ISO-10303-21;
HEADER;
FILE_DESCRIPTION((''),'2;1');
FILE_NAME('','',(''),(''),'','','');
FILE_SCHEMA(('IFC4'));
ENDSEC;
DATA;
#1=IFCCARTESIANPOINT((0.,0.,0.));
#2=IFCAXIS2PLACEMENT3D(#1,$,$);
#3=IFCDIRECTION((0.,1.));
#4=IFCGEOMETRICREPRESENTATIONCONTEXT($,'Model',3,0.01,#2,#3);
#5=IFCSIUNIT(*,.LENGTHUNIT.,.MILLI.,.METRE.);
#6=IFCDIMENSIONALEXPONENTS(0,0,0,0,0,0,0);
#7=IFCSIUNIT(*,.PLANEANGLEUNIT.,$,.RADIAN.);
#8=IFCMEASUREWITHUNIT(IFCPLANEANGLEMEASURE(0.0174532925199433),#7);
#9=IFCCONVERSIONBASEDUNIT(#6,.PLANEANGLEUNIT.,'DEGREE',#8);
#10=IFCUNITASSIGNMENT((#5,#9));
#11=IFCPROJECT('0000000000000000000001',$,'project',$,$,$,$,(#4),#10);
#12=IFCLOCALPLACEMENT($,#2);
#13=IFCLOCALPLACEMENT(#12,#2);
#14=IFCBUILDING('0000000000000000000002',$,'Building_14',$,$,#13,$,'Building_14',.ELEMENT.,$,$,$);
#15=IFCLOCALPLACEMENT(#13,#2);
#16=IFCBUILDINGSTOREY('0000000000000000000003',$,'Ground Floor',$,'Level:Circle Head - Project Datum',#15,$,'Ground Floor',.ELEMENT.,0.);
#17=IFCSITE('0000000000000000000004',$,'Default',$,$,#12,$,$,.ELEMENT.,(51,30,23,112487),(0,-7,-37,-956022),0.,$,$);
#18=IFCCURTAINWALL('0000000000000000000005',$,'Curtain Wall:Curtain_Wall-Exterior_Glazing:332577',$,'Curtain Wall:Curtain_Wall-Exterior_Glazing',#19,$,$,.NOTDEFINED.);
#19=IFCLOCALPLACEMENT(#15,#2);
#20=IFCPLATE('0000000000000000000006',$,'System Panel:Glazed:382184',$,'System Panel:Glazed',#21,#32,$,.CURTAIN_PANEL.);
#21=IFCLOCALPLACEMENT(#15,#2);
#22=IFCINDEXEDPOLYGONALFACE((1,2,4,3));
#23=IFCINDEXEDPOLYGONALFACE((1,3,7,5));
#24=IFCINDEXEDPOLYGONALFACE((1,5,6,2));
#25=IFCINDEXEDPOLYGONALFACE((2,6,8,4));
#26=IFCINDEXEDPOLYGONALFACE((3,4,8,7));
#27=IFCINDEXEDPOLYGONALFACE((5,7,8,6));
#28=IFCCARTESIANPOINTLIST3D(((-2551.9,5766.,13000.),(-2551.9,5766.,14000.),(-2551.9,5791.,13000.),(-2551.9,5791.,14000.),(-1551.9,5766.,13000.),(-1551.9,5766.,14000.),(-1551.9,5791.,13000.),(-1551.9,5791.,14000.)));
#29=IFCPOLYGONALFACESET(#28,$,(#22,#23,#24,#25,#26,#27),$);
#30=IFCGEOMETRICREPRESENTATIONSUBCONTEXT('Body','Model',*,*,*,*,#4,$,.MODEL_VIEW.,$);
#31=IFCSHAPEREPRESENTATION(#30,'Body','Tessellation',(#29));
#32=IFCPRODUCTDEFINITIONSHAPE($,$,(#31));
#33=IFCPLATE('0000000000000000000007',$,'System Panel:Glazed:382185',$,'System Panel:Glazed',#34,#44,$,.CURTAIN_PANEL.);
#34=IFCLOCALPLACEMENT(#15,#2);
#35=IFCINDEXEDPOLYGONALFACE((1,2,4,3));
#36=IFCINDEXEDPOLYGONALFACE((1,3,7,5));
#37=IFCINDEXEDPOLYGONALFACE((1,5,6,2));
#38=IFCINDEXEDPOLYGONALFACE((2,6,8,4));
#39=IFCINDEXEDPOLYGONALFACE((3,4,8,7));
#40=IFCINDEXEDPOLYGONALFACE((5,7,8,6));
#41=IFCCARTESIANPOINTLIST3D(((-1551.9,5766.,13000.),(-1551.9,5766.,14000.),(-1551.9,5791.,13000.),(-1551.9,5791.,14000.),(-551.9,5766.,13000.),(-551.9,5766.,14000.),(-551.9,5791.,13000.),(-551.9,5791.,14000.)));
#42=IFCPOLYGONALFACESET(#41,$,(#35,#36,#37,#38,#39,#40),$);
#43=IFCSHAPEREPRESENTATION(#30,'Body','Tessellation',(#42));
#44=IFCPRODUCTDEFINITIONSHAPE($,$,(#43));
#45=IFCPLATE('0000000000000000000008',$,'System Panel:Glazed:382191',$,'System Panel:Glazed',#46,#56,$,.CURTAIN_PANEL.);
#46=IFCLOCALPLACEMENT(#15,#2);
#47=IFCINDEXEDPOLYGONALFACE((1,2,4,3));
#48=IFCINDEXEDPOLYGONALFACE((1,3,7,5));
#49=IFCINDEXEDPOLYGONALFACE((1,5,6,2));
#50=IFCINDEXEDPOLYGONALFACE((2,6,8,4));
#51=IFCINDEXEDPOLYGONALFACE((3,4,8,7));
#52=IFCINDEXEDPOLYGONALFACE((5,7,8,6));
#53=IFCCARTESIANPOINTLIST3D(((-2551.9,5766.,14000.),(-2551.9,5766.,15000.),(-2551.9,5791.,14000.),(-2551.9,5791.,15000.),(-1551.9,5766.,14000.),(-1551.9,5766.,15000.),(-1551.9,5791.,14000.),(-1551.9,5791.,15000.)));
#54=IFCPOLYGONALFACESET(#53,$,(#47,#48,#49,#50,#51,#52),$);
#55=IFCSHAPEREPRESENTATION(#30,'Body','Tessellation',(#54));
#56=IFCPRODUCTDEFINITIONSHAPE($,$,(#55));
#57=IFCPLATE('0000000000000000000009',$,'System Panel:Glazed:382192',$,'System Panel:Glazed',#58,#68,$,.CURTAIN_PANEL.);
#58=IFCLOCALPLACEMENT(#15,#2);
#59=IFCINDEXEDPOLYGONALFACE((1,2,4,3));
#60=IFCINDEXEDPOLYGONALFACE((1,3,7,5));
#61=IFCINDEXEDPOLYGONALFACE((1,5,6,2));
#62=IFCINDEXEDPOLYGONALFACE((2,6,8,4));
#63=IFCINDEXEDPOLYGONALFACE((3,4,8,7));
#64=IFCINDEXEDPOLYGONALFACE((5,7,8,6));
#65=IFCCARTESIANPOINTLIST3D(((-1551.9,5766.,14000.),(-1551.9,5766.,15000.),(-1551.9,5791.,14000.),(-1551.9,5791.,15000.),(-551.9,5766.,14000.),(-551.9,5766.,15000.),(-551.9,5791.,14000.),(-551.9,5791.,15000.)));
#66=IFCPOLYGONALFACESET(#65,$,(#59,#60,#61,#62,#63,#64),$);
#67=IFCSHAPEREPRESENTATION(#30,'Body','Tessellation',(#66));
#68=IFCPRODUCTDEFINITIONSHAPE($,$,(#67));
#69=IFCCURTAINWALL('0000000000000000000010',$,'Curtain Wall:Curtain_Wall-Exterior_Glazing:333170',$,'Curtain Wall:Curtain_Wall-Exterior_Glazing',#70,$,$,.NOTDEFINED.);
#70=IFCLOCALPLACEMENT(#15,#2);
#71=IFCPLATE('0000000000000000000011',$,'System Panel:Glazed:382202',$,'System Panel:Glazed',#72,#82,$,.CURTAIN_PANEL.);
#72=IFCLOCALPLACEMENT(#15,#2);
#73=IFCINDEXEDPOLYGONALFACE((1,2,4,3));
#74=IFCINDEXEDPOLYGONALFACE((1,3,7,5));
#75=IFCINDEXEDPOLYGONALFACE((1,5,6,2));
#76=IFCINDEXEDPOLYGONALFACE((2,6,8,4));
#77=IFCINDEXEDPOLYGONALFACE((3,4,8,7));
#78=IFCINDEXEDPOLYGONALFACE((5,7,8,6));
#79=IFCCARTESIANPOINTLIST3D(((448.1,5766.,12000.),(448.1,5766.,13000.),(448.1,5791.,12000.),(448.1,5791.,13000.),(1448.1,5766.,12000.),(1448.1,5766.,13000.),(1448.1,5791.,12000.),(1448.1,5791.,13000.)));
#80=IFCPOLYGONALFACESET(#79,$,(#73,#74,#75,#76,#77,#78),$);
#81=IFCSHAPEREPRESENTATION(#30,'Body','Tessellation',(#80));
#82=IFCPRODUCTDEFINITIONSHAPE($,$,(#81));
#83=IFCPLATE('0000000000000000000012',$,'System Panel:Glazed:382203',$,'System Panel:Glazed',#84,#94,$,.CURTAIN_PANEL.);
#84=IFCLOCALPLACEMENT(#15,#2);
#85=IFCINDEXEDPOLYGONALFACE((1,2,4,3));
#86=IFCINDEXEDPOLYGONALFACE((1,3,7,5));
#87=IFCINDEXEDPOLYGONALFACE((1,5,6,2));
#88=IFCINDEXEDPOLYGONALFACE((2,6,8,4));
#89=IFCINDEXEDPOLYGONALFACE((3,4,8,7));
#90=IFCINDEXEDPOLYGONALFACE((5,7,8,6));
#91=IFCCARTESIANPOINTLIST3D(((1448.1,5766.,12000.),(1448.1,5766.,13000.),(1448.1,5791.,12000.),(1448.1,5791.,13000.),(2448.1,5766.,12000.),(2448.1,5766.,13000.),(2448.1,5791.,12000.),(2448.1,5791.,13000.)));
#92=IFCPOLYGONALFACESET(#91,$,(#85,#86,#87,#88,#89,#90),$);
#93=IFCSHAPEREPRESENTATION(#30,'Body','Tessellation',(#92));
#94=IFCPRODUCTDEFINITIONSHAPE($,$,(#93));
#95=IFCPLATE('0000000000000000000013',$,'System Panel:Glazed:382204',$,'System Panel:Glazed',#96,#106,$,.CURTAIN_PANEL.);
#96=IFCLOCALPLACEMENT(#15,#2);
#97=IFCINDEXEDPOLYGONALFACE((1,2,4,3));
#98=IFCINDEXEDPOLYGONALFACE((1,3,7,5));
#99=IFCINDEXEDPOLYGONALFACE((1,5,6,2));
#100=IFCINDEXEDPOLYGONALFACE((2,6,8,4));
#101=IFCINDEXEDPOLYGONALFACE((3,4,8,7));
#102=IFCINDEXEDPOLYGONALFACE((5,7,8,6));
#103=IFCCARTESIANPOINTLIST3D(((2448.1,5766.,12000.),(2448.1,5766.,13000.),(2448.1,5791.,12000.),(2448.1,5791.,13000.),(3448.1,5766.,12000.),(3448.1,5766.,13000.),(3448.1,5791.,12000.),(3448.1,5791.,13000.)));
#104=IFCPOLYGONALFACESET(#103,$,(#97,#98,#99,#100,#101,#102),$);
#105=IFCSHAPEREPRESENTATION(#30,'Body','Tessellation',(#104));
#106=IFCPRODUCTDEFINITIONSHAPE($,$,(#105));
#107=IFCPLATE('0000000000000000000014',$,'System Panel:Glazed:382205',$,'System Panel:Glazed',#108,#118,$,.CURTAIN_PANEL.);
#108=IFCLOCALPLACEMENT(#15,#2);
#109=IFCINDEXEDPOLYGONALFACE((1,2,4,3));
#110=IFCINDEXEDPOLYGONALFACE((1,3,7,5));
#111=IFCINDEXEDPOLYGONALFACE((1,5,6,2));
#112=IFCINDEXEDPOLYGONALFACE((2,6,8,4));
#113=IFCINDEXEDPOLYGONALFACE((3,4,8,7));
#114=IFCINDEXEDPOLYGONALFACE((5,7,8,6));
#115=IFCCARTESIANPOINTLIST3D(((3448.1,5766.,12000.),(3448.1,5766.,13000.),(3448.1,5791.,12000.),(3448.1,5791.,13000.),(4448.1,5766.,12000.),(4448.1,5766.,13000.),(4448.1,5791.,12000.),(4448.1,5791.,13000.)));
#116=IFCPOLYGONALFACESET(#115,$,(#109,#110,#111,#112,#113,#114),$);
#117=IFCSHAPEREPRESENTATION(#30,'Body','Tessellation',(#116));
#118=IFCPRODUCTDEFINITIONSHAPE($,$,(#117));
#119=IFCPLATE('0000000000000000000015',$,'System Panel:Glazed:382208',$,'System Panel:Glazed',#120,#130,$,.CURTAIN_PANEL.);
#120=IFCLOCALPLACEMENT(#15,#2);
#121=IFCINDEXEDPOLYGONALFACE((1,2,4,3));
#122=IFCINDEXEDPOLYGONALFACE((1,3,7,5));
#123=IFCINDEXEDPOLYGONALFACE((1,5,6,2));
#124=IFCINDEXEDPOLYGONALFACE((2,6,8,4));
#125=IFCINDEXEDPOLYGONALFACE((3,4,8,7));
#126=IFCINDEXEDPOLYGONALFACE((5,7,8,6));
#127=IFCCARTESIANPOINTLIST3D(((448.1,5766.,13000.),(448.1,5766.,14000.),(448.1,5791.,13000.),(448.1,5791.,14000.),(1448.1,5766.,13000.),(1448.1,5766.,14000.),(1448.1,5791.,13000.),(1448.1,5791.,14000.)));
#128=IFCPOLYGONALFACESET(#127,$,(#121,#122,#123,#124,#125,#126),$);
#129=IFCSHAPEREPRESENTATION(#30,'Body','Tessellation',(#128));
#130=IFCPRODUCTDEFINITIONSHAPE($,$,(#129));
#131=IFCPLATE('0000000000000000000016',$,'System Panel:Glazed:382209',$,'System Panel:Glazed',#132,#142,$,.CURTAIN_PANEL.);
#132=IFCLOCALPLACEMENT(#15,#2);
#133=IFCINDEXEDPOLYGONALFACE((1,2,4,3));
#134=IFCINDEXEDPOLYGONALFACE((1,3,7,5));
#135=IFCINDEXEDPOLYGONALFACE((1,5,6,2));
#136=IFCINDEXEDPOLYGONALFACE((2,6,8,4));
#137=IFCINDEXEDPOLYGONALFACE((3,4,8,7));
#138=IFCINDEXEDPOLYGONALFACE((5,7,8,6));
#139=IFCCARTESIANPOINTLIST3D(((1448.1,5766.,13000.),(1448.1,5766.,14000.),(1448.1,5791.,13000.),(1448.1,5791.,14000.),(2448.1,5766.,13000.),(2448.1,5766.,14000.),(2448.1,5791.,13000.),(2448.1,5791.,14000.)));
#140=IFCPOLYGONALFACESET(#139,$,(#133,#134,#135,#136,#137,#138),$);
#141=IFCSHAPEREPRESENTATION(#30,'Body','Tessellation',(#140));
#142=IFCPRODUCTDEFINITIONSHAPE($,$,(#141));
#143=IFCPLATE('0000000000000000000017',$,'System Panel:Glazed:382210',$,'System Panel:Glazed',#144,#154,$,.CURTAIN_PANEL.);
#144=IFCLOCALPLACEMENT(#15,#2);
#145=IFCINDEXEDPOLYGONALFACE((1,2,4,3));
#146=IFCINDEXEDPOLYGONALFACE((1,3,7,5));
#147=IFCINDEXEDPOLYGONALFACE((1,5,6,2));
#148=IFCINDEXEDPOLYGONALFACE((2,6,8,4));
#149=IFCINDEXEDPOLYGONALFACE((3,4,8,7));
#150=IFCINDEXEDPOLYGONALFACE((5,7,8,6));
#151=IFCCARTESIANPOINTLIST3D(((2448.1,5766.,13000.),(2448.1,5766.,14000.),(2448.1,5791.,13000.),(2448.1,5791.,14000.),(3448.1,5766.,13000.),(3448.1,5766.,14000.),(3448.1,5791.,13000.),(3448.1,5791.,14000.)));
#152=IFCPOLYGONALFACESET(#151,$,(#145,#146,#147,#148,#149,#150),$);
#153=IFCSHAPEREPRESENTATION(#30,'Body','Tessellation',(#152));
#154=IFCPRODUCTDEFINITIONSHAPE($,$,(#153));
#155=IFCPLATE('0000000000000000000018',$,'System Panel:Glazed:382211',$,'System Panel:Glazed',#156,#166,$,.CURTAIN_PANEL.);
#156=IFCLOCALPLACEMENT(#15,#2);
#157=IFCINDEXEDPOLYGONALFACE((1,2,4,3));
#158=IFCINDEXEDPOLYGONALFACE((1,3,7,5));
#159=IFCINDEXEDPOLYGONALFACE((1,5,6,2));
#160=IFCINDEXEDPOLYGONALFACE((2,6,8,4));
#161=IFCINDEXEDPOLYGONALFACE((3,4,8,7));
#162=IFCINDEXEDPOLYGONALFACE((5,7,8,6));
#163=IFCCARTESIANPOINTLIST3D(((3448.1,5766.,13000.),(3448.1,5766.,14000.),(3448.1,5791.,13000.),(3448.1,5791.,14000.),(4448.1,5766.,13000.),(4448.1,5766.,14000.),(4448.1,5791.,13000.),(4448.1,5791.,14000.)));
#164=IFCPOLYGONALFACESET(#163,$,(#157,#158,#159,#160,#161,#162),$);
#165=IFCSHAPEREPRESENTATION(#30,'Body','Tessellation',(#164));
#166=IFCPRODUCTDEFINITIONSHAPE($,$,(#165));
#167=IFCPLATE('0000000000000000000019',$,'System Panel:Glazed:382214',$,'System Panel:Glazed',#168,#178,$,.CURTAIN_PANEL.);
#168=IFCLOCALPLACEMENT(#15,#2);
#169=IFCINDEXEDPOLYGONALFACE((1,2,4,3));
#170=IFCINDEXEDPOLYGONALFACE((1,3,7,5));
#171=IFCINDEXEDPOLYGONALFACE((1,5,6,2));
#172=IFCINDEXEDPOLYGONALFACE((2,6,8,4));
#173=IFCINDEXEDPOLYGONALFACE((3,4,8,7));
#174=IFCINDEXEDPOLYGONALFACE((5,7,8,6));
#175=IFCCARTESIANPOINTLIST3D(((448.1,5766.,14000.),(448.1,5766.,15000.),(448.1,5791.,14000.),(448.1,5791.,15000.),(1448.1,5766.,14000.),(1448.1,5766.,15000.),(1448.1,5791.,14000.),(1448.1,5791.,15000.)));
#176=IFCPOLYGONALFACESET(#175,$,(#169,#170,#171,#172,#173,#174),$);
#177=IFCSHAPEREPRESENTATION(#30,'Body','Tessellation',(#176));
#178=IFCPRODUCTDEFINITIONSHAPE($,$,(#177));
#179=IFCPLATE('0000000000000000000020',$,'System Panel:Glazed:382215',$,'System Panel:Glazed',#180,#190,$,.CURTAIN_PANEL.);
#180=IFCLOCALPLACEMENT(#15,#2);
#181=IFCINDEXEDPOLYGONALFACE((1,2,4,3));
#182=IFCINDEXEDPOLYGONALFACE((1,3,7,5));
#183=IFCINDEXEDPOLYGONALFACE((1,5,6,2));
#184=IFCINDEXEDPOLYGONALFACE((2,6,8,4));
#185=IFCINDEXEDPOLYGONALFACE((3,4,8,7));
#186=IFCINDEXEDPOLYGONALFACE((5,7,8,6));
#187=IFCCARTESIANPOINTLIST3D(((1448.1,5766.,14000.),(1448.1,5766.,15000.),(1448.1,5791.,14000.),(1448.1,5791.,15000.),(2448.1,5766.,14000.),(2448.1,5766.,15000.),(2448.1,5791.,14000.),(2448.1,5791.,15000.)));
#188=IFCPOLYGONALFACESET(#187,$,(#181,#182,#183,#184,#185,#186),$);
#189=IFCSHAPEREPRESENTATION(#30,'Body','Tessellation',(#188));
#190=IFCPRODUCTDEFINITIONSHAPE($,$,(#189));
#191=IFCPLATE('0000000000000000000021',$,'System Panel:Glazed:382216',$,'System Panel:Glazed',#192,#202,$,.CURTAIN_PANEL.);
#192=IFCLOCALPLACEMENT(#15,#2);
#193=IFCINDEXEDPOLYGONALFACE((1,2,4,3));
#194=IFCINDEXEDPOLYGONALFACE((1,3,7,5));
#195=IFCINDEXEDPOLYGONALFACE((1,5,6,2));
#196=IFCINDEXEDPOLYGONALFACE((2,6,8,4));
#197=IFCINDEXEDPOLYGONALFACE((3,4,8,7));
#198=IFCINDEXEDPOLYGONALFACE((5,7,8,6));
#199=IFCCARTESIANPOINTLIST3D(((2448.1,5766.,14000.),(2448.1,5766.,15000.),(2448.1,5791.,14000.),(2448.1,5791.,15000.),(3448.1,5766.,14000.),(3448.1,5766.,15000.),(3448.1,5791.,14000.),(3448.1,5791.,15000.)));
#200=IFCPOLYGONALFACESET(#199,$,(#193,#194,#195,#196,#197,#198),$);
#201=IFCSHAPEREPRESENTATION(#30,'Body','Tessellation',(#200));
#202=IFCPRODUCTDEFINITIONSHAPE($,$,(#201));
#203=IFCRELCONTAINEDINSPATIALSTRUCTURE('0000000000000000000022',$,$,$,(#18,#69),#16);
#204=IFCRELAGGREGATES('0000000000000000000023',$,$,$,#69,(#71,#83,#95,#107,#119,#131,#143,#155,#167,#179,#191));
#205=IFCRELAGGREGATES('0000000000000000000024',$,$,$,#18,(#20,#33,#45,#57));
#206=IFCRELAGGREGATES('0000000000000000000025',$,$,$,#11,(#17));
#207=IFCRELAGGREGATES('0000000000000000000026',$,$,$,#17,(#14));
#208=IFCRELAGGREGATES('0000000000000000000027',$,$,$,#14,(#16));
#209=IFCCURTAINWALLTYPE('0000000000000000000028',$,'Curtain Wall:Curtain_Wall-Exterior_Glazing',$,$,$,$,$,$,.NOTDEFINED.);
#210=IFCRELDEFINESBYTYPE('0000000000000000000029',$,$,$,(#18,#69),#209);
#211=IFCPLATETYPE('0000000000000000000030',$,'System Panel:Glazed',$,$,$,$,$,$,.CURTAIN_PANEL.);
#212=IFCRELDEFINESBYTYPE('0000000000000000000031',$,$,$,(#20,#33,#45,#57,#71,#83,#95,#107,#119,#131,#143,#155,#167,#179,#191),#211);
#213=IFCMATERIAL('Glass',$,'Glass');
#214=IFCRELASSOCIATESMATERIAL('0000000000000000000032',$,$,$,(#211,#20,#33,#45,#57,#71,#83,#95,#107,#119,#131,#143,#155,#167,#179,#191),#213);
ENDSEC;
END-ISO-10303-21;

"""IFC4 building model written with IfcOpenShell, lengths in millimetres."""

from ifc_helpers import new_model, entity, si_unit, converted_unit, direction, frame, origin, place, context, subcontext, project, spatial, indexed_curve, outline, extrude, source, transform, mapped, material, type_object, type_shapes, element, aggregate, save


model = new_model("IFC4")

# Units and contexts
model_context = context("Model", 3, precision=0.01, world=origin(), true_north=direction((0.0, 1.0)))
body_context = subcontext(model_context, "Body", "Model", "MODEL_VIEW")
ifc_project = project(units=[si_unit("LENGTHUNIT", "METRE", prefix="MILLI"), converted_unit("PLANEANGLEUNIT", "DEGREE", entity("IfcPlaneAngleMeasure", 0.0174532925199433), si_unit("PLANEANGLEUNIT", "RADIAN"), dimensions=[0, 0, 0, 0, 0, 0, 0])], contexts=[model_context])

# Site, building, storey
site_placement = place(None, origin())
site = spatial("IfcSite", under=ifc_project, at=site_placement, Name="Default", CompositionType="ELEMENT", RefLatitude=(51, 30, 23, 112487), RefLongitude=(0, -7, -37, -956022), RefElevation=0.0)
building_placement = place(site_placement, origin())
building = spatial("IfcBuilding", under=site, at=building_placement, Name="Building_14", LongName="Building_14", CompositionType="ELEMENT")
storey_placement = place(building_placement, origin())
storey = spatial("IfcBuildingStorey", under=building, at=storey_placement, Name="Ground Floor", ObjectType="Level:Circle Head - Project Datum", LongName="Ground Floor", CompositionType="ELEMENT", Elevation=0.0)

# Curtain walls, plates
curtain_wall_type = type_object("IfcCurtainWallType", Name="Curtain Wall:Curtain_Wall-Exterior_Glazing", PredefinedType="NOTDEFINED")
curtain_wall_1_placement = place(storey_placement, origin())
curtain_wall_1 = element("IfcCurtainWall", 1, at=curtain_wall_1_placement, inside=storey, type_object=curtain_wall_type, Name="Curtain Wall:Curtain_Wall-Exterior_Glazing:332577", ObjectType="Curtain Wall:Curtain_Wall-Exterior_Glazing", PredefinedType="NOTDEFINED")
ifc_material = material(Name="Glass", Category="Glass")
plate_type_1 = type_object("IfcPlateType", Name="System Panel:Glazed", PredefinedType="CURTAIN_PANEL", material=ifc_material)
shared_shape_1 = source(origin(), body_context, "Body", "SweptSolid", [
    extrude(outline(indexed_curve([(-12.5, -500.0), (12.5, -500.0), (12.5, 500.0), (-12.5, 500.0), (-12.5, -500.0)], self_intersect=False)), frame((0.0, -37.0, 0.0), z_axis=(0.0, 0.0, 1.0), x_axis=(0.0, 1.0, 0.0)), (0.0, 0.0, 1.0), 1000.0),
])
type_shapes(plate_type_1, [shared_shape_1])
plate_1_placement = place(curtain_wall_1_placement, frame((-2051.9, 5815.5, 13000.0)))
plate_1 = element("IfcPlate", 2, at=plate_1_placement, type_object=plate_type_1, material=ifc_material, Name="System Panel:Glazed:382184", ObjectType="System Panel:Glazed", PredefinedType="CURTAIN_PANEL", context=body_context, shape_type="MappedRepresentation", body=[
    mapped(shared_shape_1, transform((0.0, 0.0, 0.0), scale=1.0)),
])
plate_2_placement = place(curtain_wall_1_placement, frame((-1051.9, 5815.5, 13000.0)))
plate_2 = element("IfcPlate", 3, at=plate_2_placement, type_object=plate_type_1, material=ifc_material, Name="System Panel:Glazed:382185", ObjectType="System Panel:Glazed", PredefinedType="CURTAIN_PANEL", context=body_context, shape_type="MappedRepresentation", body=[
    mapped(shared_shape_1, transform((0.0, 0.0, 0.0), scale=1.0)),
])
plate_3_placement = place(curtain_wall_1_placement, frame((-2051.9, 5815.5, 14000.0)))
plate_3 = element("IfcPlate", 4, at=plate_3_placement, type_object=plate_type_1, material=ifc_material, Name="System Panel:Glazed:382191", ObjectType="System Panel:Glazed", PredefinedType="CURTAIN_PANEL", context=body_context, shape_type="MappedRepresentation", body=[
    mapped(shared_shape_1, transform((0.0, 0.0, 0.0), scale=1.0)),
])
plate_4_placement = place(curtain_wall_1_placement, frame((-1051.9, 5815.5, 14000.0)))
plate_4 = element("IfcPlate", 5, at=plate_4_placement, type_object=plate_type_1, material=ifc_material, Name="System Panel:Glazed:382192", ObjectType="System Panel:Glazed", PredefinedType="CURTAIN_PANEL", context=body_context, shape_type="MappedRepresentation", body=[
    mapped(shared_shape_1, transform((0.0, 0.0, 0.0), scale=1.0)),
])
curtain_wall_2_placement = place(storey_placement, origin())
curtain_wall_2 = element("IfcCurtainWall", 6, at=curtain_wall_2_placement, inside=storey, type_object=curtain_wall_type, Name="Curtain Wall:Curtain_Wall-Exterior_Glazing:333170", ObjectType="Curtain Wall:Curtain_Wall-Exterior_Glazing", PredefinedType="NOTDEFINED")
plate_5_placement = place(curtain_wall_2_placement, frame((948.1, 5815.5, 12000.0)))
plate_5 = element("IfcPlate", 7, at=plate_5_placement, type_object=plate_type_1, material=ifc_material, Name="System Panel:Glazed:382202", ObjectType="System Panel:Glazed", PredefinedType="CURTAIN_PANEL", context=body_context, shape_type="MappedRepresentation", body=[
    mapped(shared_shape_1, transform((0.0, 0.0, 0.0), scale=1.0)),
])
plate_6_placement = place(curtain_wall_2_placement, frame((1948.1, 5815.5, 12000.0)))
plate_6 = element("IfcPlate", 8, at=plate_6_placement, type_object=plate_type_1, material=ifc_material, Name="System Panel:Glazed:382203", ObjectType="System Panel:Glazed", PredefinedType="CURTAIN_PANEL", context=body_context, shape_type="MappedRepresentation", body=[
    mapped(shared_shape_1, transform((0.0, 0.0, 0.0), scale=1.0)),
])
plate_7_placement = place(curtain_wall_2_placement, frame((2948.1, 5815.5, 12000.0)))
plate_7 = element("IfcPlate", 9, at=plate_7_placement, type_object=plate_type_1, material=ifc_material, Name="System Panel:Glazed:382204", ObjectType="System Panel:Glazed", PredefinedType="CURTAIN_PANEL", context=body_context, shape_type="MappedRepresentation", body=[
    mapped(shared_shape_1, transform((0.0, 0.0, 0.0), scale=1.0)),
])
plate_8_placement = place(curtain_wall_2_placement, frame((3948.1, 5815.5, 12000.0)))
plate_8 = element("IfcPlate", 10, at=plate_8_placement, type_object=plate_type_1, material=ifc_material, Name="System Panel:Glazed:382205", ObjectType="System Panel:Glazed", PredefinedType="CURTAIN_PANEL", context=body_context, shape_type="MappedRepresentation", body=[
    mapped(shared_shape_1, transform((0.0, 0.0, 0.0), scale=1.0)),
])
plate_9_placement = place(curtain_wall_2_placement, frame((948.1, 5815.5, 13000.0)))
plate_9 = element("IfcPlate", 11, at=plate_9_placement, type_object=plate_type_1, material=ifc_material, Name="System Panel:Glazed:382208", ObjectType="System Panel:Glazed", PredefinedType="CURTAIN_PANEL", context=body_context, shape_type="MappedRepresentation", body=[
    mapped(shared_shape_1, transform((0.0, 0.0, 0.0), scale=1.0)),
])
plate_10_placement = place(curtain_wall_2_placement, frame((1948.1, 5815.5, 13000.0)))
plate_10 = element("IfcPlate", 12, at=plate_10_placement, type_object=plate_type_1, material=ifc_material, Name="System Panel:Glazed:382209", ObjectType="System Panel:Glazed", PredefinedType="CURTAIN_PANEL", context=body_context, shape_type="MappedRepresentation", body=[
    mapped(shared_shape_1, transform((0.0, 0.0, 0.0), scale=1.0)),
])
plate_11_placement = place(curtain_wall_2_placement, frame((2948.1, 5815.5, 13000.0)))
plate_11 = element("IfcPlate", 13, at=plate_11_placement, type_object=plate_type_1, material=ifc_material, Name="System Panel:Glazed:382210", ObjectType="System Panel:Glazed", PredefinedType="CURTAIN_PANEL", context=body_context, shape_type="MappedRepresentation", body=[
    mapped(shared_shape_1, transform((0.0, 0.0, 0.0), scale=1.0)),
])
plate_12_placement = place(curtain_wall_2_placement, frame((3948.1, 5815.5, 13000.0)))
plate_12 = element("IfcPlate", 14, at=plate_12_placement, type_object=plate_type_1, material=ifc_material, Name="System Panel:Glazed:382211", ObjectType="System Panel:Glazed", PredefinedType="CURTAIN_PANEL", context=body_context, shape_type="MappedRepresentation", body=[
    mapped(shared_shape_1, transform((0.0, 0.0, 0.0), scale=1.0)),
])
plate_13_placement = place(curtain_wall_2_placement, frame((948.1, 5815.5, 14000.0)))
plate_13 = element("IfcPlate", 15, at=plate_13_placement, type_object=plate_type_1, material=ifc_material, Name="System Panel:Glazed:382214", ObjectType="System Panel:Glazed", PredefinedType="CURTAIN_PANEL", context=body_context, shape_type="MappedRepresentation", body=[
    mapped(shared_shape_1, transform((0.0, 0.0, 0.0), scale=1.0)),
])
plate_14_placement = place(curtain_wall_2_placement, frame((1948.1, 5815.5, 14000.0)))
plate_14 = element("IfcPlate", 16, at=plate_14_placement, type_object=plate_type_1, material=ifc_material, Name="System Panel:Glazed:382215", ObjectType="System Panel:Glazed", PredefinedType="CURTAIN_PANEL", context=body_context, shape_type="MappedRepresentation", body=[
    mapped(shared_shape_1, transform((0.0, 0.0, 0.0), scale=1.0)),
])
plate_15_placement = place(curtain_wall_2_placement, frame((2948.1, 5815.5, 14000.0)))
plate_15 = element("IfcPlate", 17, at=plate_15_placement, type_object=plate_type_1, material=ifc_material, Name="System Panel:Glazed:382216", ObjectType="System Panel:Glazed", PredefinedType="CURTAIN_PANEL", context=body_context, shape_type="MappedRepresentation", body=[
    mapped(shared_shape_1, transform((0.0, 0.0, 0.0), scale=1.0)),
])

aggregate(curtain_wall_2, [plate_5, plate_6, plate_7, plate_8, plate_9, plate_10, plate_11, plate_12, plate_13, plate_14, plate_15])
aggregate(curtain_wall_1, [plate_1, plate_2, plate_3, plate_4])

save(model, "model.ifc")
